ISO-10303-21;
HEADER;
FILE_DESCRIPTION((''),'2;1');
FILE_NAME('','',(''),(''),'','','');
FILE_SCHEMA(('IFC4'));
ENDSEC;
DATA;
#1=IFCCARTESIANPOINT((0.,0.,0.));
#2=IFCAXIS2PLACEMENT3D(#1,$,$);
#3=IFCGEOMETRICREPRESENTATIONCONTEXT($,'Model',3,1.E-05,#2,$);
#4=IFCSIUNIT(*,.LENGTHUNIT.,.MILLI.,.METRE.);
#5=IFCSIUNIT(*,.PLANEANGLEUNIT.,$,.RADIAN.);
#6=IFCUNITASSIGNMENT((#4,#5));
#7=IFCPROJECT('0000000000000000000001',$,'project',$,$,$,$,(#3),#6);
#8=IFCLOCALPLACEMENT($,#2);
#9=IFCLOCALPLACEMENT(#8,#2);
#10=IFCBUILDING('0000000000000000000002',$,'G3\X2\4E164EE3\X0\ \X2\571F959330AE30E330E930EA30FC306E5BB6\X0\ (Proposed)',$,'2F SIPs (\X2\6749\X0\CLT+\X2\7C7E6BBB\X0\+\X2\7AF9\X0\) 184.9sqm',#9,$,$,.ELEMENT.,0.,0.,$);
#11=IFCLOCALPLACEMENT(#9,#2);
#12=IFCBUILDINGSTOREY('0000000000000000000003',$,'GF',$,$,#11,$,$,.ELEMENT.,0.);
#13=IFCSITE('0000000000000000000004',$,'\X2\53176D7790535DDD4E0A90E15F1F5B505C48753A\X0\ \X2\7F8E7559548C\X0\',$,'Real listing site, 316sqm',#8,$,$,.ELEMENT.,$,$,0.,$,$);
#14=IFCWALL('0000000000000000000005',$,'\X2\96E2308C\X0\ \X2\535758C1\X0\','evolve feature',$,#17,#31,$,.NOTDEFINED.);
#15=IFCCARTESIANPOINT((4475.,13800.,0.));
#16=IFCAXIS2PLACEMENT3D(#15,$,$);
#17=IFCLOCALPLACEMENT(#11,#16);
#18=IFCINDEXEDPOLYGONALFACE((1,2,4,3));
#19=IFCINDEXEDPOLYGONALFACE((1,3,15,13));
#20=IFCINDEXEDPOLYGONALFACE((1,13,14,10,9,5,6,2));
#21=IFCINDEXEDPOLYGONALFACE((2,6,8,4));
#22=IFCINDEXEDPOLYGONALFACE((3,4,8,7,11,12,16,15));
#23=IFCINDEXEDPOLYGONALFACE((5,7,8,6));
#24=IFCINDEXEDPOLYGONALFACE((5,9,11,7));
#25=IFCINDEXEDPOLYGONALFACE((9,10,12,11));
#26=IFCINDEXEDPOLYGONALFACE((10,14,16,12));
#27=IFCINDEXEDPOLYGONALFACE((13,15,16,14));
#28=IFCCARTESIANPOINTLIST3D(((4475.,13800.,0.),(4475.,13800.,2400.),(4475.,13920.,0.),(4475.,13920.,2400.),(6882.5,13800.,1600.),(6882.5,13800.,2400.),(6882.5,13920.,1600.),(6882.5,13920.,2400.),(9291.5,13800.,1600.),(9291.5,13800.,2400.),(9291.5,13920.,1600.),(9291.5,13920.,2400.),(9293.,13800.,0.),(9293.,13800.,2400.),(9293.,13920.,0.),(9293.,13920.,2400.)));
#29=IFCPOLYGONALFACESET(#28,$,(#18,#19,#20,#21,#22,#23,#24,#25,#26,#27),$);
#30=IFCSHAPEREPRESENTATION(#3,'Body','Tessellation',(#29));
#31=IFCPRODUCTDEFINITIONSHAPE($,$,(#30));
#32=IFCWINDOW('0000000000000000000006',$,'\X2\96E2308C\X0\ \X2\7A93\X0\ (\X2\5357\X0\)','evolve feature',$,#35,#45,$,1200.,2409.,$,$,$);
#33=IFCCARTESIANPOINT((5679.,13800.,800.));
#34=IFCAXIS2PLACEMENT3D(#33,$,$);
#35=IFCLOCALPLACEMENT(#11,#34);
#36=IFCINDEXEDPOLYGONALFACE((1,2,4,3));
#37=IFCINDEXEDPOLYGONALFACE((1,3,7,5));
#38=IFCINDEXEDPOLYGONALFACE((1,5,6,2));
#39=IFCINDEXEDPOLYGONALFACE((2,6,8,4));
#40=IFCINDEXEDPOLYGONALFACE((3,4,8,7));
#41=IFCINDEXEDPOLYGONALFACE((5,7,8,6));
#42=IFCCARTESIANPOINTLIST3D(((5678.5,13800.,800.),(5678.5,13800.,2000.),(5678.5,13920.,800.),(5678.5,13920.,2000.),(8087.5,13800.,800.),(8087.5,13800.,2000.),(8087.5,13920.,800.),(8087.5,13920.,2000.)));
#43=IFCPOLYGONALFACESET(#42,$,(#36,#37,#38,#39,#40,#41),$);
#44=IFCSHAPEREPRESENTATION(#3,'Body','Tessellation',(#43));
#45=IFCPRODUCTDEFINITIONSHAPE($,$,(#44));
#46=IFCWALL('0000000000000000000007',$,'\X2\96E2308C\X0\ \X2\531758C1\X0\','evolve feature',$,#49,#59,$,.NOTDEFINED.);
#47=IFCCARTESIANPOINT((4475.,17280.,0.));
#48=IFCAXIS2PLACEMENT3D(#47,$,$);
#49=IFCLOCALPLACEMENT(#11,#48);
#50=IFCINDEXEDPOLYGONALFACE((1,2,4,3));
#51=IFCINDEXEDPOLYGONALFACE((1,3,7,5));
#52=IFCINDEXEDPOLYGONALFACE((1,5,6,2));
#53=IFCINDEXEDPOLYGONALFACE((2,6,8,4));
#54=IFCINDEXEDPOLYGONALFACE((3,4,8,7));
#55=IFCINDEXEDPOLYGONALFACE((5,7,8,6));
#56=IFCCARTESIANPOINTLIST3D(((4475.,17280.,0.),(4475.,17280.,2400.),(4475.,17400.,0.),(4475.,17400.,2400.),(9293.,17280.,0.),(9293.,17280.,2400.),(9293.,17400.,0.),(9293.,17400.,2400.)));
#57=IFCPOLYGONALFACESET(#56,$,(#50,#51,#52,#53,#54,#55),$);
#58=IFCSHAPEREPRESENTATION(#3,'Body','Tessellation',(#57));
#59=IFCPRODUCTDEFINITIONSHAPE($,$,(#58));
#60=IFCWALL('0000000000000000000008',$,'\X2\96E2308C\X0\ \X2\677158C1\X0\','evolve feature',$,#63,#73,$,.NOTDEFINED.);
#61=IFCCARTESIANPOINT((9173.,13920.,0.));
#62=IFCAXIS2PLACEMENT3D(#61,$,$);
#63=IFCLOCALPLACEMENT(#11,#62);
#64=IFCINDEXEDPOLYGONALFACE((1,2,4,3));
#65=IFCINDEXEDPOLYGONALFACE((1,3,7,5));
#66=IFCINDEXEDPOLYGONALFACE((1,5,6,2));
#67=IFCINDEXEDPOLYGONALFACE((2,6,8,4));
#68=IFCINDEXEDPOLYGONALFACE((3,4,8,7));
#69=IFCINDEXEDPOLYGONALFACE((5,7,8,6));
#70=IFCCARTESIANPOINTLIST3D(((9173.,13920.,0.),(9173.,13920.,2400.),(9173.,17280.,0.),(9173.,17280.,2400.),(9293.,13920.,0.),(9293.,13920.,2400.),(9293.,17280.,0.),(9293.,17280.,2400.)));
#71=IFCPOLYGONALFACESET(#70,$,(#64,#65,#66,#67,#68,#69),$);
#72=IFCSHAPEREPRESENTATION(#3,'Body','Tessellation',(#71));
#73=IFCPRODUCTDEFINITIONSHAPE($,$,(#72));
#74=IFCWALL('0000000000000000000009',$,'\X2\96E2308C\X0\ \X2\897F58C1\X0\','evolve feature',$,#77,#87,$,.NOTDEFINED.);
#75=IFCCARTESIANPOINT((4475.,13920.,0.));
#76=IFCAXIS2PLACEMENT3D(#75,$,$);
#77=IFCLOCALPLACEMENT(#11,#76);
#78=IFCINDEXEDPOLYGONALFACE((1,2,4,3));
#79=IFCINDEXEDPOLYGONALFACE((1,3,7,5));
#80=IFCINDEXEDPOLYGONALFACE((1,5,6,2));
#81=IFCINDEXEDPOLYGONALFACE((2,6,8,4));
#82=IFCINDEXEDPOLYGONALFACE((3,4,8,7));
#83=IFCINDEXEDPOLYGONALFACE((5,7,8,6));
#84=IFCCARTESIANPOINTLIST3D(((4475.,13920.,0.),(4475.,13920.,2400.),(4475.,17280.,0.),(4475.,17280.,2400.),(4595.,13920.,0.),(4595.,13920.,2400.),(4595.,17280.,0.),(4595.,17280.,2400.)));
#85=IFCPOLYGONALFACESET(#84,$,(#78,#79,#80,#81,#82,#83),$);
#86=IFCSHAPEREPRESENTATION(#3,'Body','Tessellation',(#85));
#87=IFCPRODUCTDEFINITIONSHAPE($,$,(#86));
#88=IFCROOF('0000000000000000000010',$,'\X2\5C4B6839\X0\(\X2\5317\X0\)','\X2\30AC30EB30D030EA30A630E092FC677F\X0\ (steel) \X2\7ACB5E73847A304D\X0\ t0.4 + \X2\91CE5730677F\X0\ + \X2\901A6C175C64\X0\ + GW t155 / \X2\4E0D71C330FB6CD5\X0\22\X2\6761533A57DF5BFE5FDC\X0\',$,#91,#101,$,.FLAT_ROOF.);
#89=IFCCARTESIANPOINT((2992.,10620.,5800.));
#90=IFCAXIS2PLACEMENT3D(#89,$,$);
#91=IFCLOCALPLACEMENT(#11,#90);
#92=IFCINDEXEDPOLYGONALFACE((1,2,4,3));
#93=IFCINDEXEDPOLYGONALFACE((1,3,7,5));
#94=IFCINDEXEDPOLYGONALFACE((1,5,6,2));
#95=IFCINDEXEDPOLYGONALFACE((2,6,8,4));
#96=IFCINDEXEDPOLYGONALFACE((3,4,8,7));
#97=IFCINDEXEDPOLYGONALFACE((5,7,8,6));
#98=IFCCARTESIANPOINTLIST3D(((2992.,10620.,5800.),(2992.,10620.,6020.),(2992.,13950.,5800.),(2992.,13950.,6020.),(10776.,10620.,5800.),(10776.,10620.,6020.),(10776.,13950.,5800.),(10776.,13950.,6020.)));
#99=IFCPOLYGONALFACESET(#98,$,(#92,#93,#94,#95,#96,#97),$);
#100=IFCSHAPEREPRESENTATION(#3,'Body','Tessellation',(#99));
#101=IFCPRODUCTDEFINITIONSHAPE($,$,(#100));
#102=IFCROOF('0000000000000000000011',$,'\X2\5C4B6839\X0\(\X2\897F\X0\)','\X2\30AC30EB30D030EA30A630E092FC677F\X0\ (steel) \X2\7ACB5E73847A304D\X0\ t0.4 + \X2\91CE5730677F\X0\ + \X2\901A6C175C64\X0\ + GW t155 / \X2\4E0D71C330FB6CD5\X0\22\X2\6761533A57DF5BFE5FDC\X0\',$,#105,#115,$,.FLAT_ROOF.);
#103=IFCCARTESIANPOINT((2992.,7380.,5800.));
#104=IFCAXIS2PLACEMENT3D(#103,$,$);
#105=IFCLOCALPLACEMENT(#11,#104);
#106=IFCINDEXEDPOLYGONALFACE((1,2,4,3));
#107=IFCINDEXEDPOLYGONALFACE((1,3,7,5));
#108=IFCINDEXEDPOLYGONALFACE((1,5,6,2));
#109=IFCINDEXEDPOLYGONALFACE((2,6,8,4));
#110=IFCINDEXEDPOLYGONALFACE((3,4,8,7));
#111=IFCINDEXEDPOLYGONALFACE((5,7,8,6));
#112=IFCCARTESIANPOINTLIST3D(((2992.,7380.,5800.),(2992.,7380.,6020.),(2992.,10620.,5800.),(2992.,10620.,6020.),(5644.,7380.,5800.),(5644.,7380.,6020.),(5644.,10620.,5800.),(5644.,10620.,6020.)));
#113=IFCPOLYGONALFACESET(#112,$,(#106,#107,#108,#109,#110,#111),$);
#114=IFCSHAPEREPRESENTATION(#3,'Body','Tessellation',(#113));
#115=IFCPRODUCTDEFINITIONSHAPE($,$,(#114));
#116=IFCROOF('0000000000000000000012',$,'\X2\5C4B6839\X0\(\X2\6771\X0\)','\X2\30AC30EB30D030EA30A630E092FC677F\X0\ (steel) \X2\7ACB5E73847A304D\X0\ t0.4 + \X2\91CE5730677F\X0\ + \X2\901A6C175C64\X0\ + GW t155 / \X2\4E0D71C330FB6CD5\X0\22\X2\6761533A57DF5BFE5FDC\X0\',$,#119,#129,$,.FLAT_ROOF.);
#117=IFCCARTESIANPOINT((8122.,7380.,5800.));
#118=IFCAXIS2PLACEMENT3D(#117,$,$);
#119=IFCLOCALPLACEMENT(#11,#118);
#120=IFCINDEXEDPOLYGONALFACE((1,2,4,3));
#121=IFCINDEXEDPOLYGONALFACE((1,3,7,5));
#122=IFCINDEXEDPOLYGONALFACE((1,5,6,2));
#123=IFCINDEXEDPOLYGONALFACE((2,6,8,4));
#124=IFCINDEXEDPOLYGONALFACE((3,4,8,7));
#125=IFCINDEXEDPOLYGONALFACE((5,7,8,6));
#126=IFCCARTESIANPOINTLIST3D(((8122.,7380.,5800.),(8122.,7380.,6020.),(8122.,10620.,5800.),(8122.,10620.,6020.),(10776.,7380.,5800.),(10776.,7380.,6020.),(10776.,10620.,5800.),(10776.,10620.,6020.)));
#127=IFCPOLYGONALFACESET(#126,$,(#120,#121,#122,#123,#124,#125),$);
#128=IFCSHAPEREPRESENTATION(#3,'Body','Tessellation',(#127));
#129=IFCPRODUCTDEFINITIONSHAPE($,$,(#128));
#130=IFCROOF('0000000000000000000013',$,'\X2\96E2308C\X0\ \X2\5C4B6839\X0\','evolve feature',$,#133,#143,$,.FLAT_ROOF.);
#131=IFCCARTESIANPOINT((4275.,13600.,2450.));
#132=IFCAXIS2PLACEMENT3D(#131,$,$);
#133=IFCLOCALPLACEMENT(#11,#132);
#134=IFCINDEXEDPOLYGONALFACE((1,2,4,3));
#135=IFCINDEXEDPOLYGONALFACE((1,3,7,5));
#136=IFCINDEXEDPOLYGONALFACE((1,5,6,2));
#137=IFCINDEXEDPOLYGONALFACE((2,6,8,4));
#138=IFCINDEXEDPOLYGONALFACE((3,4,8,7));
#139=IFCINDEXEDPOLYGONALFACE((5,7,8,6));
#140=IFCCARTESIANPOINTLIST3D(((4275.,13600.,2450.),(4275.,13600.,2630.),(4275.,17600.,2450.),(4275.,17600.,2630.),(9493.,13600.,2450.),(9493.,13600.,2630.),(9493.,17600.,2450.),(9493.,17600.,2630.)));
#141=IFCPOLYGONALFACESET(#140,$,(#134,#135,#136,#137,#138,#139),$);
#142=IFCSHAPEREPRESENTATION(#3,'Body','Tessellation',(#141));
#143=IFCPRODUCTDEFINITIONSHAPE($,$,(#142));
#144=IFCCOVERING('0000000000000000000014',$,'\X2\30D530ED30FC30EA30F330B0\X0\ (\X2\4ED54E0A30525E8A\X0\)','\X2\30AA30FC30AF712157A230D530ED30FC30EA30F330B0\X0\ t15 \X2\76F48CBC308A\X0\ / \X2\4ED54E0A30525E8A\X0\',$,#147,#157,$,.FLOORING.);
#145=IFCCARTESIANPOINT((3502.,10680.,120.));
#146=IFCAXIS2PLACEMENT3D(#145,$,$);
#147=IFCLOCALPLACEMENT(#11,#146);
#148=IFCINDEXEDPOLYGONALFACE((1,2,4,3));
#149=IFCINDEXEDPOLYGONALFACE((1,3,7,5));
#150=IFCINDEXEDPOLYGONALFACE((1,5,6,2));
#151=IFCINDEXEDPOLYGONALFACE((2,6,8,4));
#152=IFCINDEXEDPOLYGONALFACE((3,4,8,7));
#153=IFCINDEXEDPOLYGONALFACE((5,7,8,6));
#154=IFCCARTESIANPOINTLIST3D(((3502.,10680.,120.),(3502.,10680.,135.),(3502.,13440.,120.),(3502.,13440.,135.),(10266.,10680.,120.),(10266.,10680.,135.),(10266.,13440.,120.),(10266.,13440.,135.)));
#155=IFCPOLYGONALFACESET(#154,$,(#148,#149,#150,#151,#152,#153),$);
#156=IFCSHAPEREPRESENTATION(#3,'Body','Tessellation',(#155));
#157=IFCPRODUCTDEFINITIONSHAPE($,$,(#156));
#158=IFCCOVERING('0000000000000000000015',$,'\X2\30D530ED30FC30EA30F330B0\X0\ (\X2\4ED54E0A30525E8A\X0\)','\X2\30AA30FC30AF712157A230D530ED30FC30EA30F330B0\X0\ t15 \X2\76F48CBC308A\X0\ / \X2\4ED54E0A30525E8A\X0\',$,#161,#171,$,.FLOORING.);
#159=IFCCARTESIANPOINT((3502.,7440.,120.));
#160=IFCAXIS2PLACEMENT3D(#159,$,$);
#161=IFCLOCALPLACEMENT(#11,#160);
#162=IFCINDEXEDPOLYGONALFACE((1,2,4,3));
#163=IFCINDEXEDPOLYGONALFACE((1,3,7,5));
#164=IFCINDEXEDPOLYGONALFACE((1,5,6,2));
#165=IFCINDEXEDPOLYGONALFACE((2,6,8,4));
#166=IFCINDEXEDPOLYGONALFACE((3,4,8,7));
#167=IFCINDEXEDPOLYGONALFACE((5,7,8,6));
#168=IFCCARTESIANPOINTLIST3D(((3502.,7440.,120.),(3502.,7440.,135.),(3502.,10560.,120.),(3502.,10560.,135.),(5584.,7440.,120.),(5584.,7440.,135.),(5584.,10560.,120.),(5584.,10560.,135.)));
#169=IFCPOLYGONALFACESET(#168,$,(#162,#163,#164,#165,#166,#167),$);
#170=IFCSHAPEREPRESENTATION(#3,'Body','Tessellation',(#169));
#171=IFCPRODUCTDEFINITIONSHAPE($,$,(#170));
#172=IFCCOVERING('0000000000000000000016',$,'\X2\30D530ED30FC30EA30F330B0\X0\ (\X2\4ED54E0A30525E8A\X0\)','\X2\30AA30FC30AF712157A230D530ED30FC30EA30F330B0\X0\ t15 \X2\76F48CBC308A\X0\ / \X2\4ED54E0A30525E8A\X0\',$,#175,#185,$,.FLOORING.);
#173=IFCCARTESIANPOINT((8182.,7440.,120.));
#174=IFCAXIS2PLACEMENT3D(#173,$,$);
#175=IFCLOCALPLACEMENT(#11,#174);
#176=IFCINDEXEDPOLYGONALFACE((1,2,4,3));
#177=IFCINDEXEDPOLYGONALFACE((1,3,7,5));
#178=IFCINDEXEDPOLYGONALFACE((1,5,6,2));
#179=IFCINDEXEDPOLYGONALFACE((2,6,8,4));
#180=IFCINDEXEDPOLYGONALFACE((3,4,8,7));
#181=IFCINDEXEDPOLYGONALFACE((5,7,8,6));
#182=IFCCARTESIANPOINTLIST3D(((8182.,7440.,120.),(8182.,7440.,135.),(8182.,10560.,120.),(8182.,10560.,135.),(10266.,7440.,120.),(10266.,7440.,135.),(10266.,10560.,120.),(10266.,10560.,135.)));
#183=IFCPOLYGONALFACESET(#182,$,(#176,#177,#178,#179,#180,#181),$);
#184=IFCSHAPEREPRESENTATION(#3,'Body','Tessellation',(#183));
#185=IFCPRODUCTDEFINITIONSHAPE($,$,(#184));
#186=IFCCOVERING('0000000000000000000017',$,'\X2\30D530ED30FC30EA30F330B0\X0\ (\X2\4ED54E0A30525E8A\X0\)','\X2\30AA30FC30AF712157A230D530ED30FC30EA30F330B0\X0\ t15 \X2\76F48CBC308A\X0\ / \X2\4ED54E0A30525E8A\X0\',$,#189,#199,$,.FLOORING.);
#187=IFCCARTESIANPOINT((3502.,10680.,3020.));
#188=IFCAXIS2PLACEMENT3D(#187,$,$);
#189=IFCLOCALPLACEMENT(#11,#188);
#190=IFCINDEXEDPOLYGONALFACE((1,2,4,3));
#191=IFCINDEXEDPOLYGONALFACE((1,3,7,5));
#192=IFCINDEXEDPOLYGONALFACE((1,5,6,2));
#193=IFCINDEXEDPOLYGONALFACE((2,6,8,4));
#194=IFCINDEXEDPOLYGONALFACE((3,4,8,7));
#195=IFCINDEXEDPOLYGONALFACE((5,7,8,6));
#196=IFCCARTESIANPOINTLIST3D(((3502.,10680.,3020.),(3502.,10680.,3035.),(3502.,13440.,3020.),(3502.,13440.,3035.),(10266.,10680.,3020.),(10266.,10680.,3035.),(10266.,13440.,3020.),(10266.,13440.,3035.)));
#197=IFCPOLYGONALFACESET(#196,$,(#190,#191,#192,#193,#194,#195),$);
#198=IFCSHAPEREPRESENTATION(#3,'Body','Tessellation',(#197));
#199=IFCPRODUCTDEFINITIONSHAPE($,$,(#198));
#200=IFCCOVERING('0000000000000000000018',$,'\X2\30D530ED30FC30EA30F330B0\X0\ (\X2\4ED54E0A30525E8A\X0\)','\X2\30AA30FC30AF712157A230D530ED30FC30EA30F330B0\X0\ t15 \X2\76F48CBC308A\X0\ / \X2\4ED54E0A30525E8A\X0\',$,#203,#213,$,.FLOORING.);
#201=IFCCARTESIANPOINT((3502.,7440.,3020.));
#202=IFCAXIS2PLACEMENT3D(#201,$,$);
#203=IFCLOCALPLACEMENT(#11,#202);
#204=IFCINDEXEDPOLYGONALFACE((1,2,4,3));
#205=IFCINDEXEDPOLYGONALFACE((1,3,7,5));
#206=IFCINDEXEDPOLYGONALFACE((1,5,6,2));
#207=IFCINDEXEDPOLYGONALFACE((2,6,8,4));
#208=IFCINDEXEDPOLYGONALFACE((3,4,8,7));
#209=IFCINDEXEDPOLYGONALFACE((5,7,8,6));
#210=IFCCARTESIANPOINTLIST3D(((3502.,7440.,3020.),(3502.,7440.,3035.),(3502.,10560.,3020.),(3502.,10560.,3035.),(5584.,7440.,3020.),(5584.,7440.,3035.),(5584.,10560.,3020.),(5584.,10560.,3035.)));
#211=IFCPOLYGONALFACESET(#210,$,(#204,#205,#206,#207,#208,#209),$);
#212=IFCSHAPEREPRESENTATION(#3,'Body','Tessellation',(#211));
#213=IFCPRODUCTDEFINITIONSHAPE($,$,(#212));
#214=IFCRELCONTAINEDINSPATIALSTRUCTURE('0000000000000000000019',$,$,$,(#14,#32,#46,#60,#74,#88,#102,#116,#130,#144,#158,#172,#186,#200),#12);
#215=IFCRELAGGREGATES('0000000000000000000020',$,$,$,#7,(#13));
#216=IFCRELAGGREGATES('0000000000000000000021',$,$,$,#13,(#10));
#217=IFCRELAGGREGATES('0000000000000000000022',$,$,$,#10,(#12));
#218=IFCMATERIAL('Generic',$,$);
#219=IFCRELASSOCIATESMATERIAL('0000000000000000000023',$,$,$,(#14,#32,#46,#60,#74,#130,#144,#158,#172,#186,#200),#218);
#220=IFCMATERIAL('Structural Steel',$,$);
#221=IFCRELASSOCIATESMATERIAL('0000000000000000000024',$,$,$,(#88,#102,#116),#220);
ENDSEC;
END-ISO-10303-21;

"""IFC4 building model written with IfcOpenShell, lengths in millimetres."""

from ifc_helpers import new_model, si_unit, frame, frame_2d, origin, place, context, project, spatial, rectangle, extrude, material, element, fill, save


model = new_model("IFC4")

# Units and contexts
model_context = context("Model", 3, precision=1e-05, world=origin())
ifc_project = project(units=[si_unit("LENGTHUNIT", "METRE", prefix="MILLI"), si_unit("PLANEANGLEUNIT", "RADIAN")], contexts=[model_context])

# Site, building, storey
site_placement = place(None, origin())
site = spatial("IfcSite", under=ifc_project, at=site_placement, Name="北海道川上郡弟子屈町 美留和", ObjectType="Real listing site, 316sqm", CompositionType="ELEMENT", RefElevation=0.0)
building_placement = place(site_placement, origin())
building = spatial("IfcBuilding", under=site, at=building_placement, Name="G3世代 土間ギャラリーの家 (Proposed)", ObjectType="2F SIPs (杉CLT+籾殻+竹) 184.9sqm", CompositionType="ELEMENT", ElevationOfRefHeight=0.0, ElevationOfTerrain=0.0)
storey_placement = place(building_placement, origin())
storey = spatial("IfcBuildingStorey", under=building, at=storey_placement, Name="GF", CompositionType="ELEMENT", Elevation=0.0)

# Shared definitions
ifc_material_1 = material(Name="Generic")

# Wall, opening, window
wall_1_placement = place(storey_placement, frame((4475.0, 13800.0, 0.0)))
wall_1 = element("IfcWall", 1, at=wall_1_placement, inside=storey, material=ifc_material_1, Name="離れ 南壁", Description="evolve feature", PredefinedType="NOTDEFINED", context=model_context, shape_type="SweptSolid", body=[
    extrude(rectangle(XDim=4818.0, YDim=120.0, at=frame_2d((2409.0, 60.0))), frame((4475.0, 13800.0, 0.0)), (0.0, 0.0, 1.0), 2400.0),
])
opening_1_placement = place(storey_placement, frame((5679.0, 13800.0, 800.0)))
opening_1 = element("IfcOpeningElement", 2, at=opening_1_placement, cuts=wall_1, PredefinedType="NOTDEFINED", context=model_context, shape_type="SweptSolid", body=[
    extrude(rectangle(XDim=2409.0, YDim=120.0, at=frame_2d((1204.0, 60.0))), frame((5679.0, 13800.0, 800.0)), (0.0, 0.0, 1.0), 1200.0),
])
window_1_placement = place(storey_placement, frame((5679.0, 13800.0, 800.0)))
window_1 = element("IfcWindow", 3, at=window_1_placement, inside=storey, material=ifc_material_1, Name="離れ 窓 (南)", Description="evolve feature", OverallHeight=1200.0, OverallWidth=2409.0, context=model_context, shape_type="SweptSolid", body=[
    extrude(rectangle(XDim=2409.0, YDim=120.0, at=frame_2d((1204.0, 60.0))), frame((5679.0, 13800.0, 800.0)), (0.0, 0.0, 1.0), 1200.0),
])
fill(opening_1, window_1)

# Walls
wall_2_placement = place(storey_placement, frame((4475.0, 17280.0, 0.0)))
element("IfcWall", 4, at=wall_2_placement, inside=storey, material=ifc_material_1, Name="離れ 北壁", Description="evolve feature", PredefinedType="NOTDEFINED", context=model_context, shape_type="SweptSolid", body=[
    extrude(rectangle(XDim=4818.0, YDim=120.0, at=frame_2d((2409.0, 60.0))), frame((4475.0, 17280.0, 0.0)), (0.0, 0.0, 1.0), 2400.0),
])
wall_3_placement = place(storey_placement, frame((9173.0, 13920.0, 0.0)))
element("IfcWall", 5, at=wall_3_placement, inside=storey, material=ifc_material_1, Name="離れ 東壁", Description="evolve feature", PredefinedType="NOTDEFINED", context=model_context, shape_type="SweptSolid", body=[
    extrude(rectangle(XDim=120.0, YDim=3360.0, at=frame_2d((60.0, 1680.0))), frame((9173.0, 13920.0, 0.0)), (0.0, 0.0, 1.0), 2400.0),
])
wall_4_placement = place(storey_placement, frame((4475.0, 13920.0, 0.0)))
element("IfcWall", 6, at=wall_4_placement, inside=storey, material=ifc_material_1, Name="離れ 西壁", Description="evolve feature", PredefinedType="NOTDEFINED", context=model_context, shape_type="SweptSolid", body=[
    extrude(rectangle(XDim=120.0, YDim=3360.0, at=frame_2d((60.0, 1680.0))), frame((4475.0, 13920.0, 0.0)), (0.0, 0.0, 1.0), 2400.0),
])

# Roofs
ifc_material_2 = material(Name="Structural Steel")
for number, where, name in (
    (7, (2992.0, 10620.0, 5800.0), "屋根(北)"),
):
    element("IfcRoof", number, at=place(storey_placement, frame(where)), inside=storey, material=ifc_material_2, Name=name, Description="ガルバリウム鋼板 (steel) 立平葺き t0.4 + 野地板 + 通気層 + GW t155 / 不燃・法22条区域対応", PredefinedType="FLAT_ROOF", context=model_context, shape_type="SweptSolid", body=[
        extrude(rectangle(XDim=7784.0, YDim=3330.0, at=frame_2d((3892.0, 1665.0))), frame((2992.0, 10620.0, 5800.0)), (0.0, 0.0, 1.0), 220.0),
    ])
roof_1_placement = place(storey_placement, frame((2992.0, 7380.0, 5800.0)))
element("IfcRoof", 8, at=roof_1_placement, inside=storey, material=ifc_material_2, Name="屋根(西)", Description="ガルバリウム鋼板 (steel) 立平葺き t0.4 + 野地板 + 通気層 + GW t155 / 不燃・法22条区域対応", PredefinedType="FLAT_ROOF", context=model_context, shape_type="SweptSolid", body=[
    extrude(rectangle(XDim=2652.0, YDim=3240.0, at=frame_2d((1326.0, 1620.0))), frame((2992.0, 7380.0, 5800.0)), (0.0, 0.0, 1.0), 220.0),
])
roof_2_placement = place(storey_placement, frame((8122.0, 7380.0, 5800.0)))
element("IfcRoof", 9, at=roof_2_placement, inside=storey, material=ifc_material_2, Name="屋根(東)", Description="ガルバリウム鋼板 (steel) 立平葺き t0.4 + 野地板 + 通気層 + GW t155 / 不燃・法22条区域対応", PredefinedType="FLAT_ROOF", context=model_context, shape_type="SweptSolid", body=[
    extrude(rectangle(XDim=2654.0, YDim=3240.0, at=frame_2d((1327.0, 1620.0))), frame((8122.0, 7380.0, 5800.0)), (0.0, 0.0, 1.0), 220.0),
])
roof_3_placement = place(storey_placement, frame((4275.0, 13600.0, 2450.0)))
element("IfcRoof", 10, at=roof_3_placement, inside=storey, material=ifc_material_1, Name="離れ 屋根", Description="evolve feature", PredefinedType="FLAT_ROOF", context=model_context, shape_type="SweptSolid", body=[
    extrude(rectangle(XDim=5218.0, YDim=4000.0, at=frame_2d((2609.0, 2000.0))), frame((4275.0, 13600.0, 2450.0)), (0.0, 0.0, 1.0), 180.0),
])

# Coverings
covering_1_placement = place(storey_placement, frame((3502.0, 10680.0, 120.0)))
element("IfcCovering", 11, at=covering_1_placement, inside=storey, material=ifc_material_1, Name="フローリング (仕上げ床)", Description="オーク無垢フローリング t15 直貼り / 仕上げ床", PredefinedType="FLOORING", context=model_context, shape_type="SweptSolid", body=[
    extrude(rectangle(XDim=6764.0, YDim=2760.0, at=frame_2d((3382.0, 1380.0))), frame((3502.0, 10680.0, 120.0)), (0.0, 0.0, 1.0), 15.0),
])
covering_2_placement = place(storey_placement, frame((3502.0, 7440.0, 120.0)))
element("IfcCovering", 12, at=covering_2_placement, inside=storey, material=ifc_material_1, Name="フローリング (仕上げ床)", Description="オーク無垢フローリング t15 直貼り / 仕上げ床", PredefinedType="FLOORING", context=model_context, shape_type="SweptSolid", body=[
    extrude(rectangle(XDim=2082.0, YDim=3120.0, at=frame_2d((1041.0, 1560.0))), frame((3502.0, 7440.0, 120.0)), (0.0, 0.0, 1.0), 15.0),
])
covering_3_placement = place(storey_placement, frame((8182.0, 7440.0, 120.0)))
element("IfcCovering", 13, at=covering_3_placement, inside=storey, material=ifc_material_1, Name="フローリング (仕上げ床)", Description="オーク無垢フローリング t15 直貼り / 仕上げ床", PredefinedType="FLOORING", context=model_context, shape_type="SweptSolid", body=[
    extrude(rectangle(XDim=2084.0, YDim=3120.0, at=frame_2d((1042.0, 1560.0))), frame((8182.0, 7440.0, 120.0)), (0.0, 0.0, 1.0), 15.0),
])
covering_4_placement = place(storey_placement, frame((3502.0, 10680.0, 3020.0)))
element("IfcCovering", 14, at=covering_4_placement, inside=storey, material=ifc_material_1, Name="フローリング (仕上げ床)", Description="オーク無垢フローリング t15 直貼り / 仕上げ床", PredefinedType="FLOORING", context=model_context, shape_type="SweptSolid", body=[
    extrude(rectangle(XDim=6764.0, YDim=2760.0, at=frame_2d((3382.0, 1380.0))), frame((3502.0, 10680.0, 3020.0)), (0.0, 0.0, 1.0), 15.0),
])
covering_5_placement = place(storey_placement, frame((3502.0, 7440.0, 3020.0)))
element("IfcCovering", 15, at=covering_5_placement, inside=storey, material=ifc_material_1, Name="フローリング (仕上げ床)", Description="オーク無垢フローリング t15 直貼り / 仕上げ床", PredefinedType="FLOORING", context=model_context, shape_type="SweptSolid", body=[
    extrude(rectangle(XDim=2082.0, YDim=3120.0, at=frame_2d((1041.0, 1560.0))), frame((3502.0, 7440.0, 3020.0)), (0.0, 0.0, 1.0), 15.0),
])

save(model, "model.ifc")
